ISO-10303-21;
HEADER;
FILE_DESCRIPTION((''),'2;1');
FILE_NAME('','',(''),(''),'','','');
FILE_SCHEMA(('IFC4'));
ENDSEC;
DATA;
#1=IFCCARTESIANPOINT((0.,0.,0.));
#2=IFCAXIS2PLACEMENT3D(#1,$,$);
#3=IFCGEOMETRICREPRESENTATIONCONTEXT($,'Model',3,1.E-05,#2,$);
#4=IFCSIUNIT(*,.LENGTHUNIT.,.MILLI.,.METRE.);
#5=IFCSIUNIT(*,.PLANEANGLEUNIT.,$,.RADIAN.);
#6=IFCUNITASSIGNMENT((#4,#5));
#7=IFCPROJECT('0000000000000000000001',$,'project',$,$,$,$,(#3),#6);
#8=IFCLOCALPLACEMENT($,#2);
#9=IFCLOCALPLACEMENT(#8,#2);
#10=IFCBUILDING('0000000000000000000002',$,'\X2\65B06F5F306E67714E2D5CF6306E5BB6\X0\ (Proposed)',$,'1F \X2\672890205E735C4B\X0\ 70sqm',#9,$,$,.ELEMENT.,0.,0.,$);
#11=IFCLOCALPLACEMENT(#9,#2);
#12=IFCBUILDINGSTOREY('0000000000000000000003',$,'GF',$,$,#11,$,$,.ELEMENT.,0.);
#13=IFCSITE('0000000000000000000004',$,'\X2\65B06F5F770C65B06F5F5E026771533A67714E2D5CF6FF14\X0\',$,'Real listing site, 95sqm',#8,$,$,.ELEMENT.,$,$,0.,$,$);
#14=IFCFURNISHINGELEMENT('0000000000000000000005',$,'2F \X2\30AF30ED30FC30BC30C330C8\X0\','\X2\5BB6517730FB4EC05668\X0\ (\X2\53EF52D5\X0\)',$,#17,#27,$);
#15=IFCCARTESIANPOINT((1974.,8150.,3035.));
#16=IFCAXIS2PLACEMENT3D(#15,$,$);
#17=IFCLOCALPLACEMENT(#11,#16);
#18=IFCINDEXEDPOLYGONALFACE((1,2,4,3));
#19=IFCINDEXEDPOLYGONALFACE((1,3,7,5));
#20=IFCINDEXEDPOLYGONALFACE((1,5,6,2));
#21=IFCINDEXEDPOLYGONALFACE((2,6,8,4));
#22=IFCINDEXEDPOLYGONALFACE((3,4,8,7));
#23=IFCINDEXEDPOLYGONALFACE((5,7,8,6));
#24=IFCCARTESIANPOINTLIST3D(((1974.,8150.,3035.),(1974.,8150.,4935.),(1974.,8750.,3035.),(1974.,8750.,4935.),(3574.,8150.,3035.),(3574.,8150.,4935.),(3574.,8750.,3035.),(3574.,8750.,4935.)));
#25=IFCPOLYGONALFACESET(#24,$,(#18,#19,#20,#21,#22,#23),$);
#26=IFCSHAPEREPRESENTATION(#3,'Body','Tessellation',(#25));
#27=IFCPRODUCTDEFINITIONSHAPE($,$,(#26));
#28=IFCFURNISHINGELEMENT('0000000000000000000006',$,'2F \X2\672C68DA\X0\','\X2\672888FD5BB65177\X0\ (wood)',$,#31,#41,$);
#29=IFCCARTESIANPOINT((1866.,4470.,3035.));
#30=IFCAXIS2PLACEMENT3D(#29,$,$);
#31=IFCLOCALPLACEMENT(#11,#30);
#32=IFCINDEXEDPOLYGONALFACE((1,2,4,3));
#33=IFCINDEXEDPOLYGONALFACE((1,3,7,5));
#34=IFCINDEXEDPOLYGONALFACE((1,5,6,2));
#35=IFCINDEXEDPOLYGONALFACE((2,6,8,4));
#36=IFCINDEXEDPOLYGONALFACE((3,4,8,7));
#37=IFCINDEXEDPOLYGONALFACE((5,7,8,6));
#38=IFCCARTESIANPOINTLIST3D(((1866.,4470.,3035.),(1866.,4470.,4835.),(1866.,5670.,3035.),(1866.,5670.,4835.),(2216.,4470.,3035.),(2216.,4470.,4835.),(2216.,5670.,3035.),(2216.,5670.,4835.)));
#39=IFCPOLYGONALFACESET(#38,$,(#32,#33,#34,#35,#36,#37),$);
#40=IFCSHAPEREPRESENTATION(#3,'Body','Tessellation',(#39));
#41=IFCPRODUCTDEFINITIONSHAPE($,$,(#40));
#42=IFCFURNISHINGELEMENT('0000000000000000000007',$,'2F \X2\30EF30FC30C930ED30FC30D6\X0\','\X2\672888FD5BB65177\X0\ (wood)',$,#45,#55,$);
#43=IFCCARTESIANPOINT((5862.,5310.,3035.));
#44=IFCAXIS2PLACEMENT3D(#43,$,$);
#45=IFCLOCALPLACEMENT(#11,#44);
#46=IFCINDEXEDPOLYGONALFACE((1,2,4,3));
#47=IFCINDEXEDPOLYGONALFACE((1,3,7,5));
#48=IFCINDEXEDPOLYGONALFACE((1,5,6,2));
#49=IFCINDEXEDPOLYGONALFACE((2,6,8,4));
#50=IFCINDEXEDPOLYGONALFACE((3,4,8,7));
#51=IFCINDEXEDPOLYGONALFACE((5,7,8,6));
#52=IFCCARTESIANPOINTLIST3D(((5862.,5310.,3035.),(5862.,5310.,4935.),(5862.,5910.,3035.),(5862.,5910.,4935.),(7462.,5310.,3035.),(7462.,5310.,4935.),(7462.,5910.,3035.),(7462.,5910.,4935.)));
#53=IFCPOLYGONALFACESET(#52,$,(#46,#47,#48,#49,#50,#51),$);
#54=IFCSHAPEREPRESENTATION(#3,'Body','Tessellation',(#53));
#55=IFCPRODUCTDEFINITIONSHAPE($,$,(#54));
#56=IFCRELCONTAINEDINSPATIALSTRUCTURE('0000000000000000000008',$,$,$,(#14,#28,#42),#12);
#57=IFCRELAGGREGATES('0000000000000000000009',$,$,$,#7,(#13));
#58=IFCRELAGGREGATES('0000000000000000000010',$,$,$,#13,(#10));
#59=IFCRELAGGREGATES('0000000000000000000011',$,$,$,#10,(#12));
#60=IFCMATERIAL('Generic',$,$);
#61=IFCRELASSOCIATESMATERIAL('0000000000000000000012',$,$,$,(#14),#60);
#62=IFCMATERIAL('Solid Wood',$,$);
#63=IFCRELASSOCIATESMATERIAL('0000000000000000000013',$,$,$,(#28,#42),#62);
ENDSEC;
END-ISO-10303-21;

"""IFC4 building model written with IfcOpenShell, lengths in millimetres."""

from ifc_helpers import new_model, si_unit, frame, frame_2d, origin, place, context, project, spatial, rectangle, extrude, material, element, save


model = new_model("IFC4")

# Units and contexts
model_context = context("Model", 3, precision=1e-05, world=origin())
ifc_project = project(units=[si_unit("LENGTHUNIT", "METRE", prefix="MILLI"), si_unit("PLANEANGLEUNIT", "RADIAN")], contexts=[model_context])

# Site, building, storey
site_placement = place(None, origin())
site = spatial("IfcSite", under=ifc_project, at=site_placement, Name="新潟県新潟市東区東中島４", ObjectType="Real listing site, 95sqm", CompositionType="ELEMENT", RefElevation=0.0)
building_placement = place(site_placement, origin())
building = spatial("IfcBuilding", under=site, at=building_placement, Name="新潟の東中島の家 (Proposed)", ObjectType="1F 木造平屋 70sqm", CompositionType="ELEMENT", ElevationOfRefHeight=0.0, ElevationOfTerrain=0.0)
storey_placement = place(building_placement, origin())
storey = spatial("IfcBuildingStorey", under=building, at=storey_placement, Name="GF", CompositionType="ELEMENT", Elevation=0.0)

# Shared definitions
ifc_material_1 = material(Name="Solid Wood")

# Shared definitions
ifc_material_2 = material(Name="Generic")

# Furnishing elements
furnishing_1_placement = place(storey_placement, frame((1974.0, 8150.0, 3035.0)))
element("IfcFurnishingElement", 1, at=furnishing_1_placement, inside=storey, material=ifc_material_2, Name="2F クローゼット", Description="家具・什器 (可動)", context=model_context, shape_type="SweptSolid", body=[
    extrude(rectangle(XDim=1600.0, YDim=600.0, at=frame_2d((800.0, 300.0))), frame((1974.0, 8150.0, 3035.0)), (0.0, 0.0, 1.0), 1900.0),
])
furnishing_2_placement = place(storey_placement, frame((1866.0, 4470.0, 3035.0)))
element("IfcFurnishingElement", 2, at=furnishing_2_placement, inside=storey, material=ifc_material_1, Name="2F 本棚", Description="木製家具 (wood)", context=model_context, shape_type="SweptSolid", body=[
    extrude(rectangle(XDim=350.0, YDim=1200.0, at=frame_2d((175.0, 600.0))), frame((1866.0, 4470.0, 3035.0)), (0.0, 0.0, 1.0), 1800.0),
])
furnishing_3_placement = place(storey_placement, frame((5862.0, 5310.0, 3035.0)))
element("IfcFurnishingElement", 3, at=furnishing_3_placement, inside=storey, material=ifc_material_1, Name="2F ワードローブ", Description="木製家具 (wood)", context=model_context, shape_type="SweptSolid", body=[
    extrude(rectangle(XDim=1600.0, YDim=600.0, at=frame_2d((800.0, 300.0))), frame((5862.0, 5310.0, 3035.0)), (0.0, 0.0, 1.0), 1900.0),
])

save(model, "model.ifc")
